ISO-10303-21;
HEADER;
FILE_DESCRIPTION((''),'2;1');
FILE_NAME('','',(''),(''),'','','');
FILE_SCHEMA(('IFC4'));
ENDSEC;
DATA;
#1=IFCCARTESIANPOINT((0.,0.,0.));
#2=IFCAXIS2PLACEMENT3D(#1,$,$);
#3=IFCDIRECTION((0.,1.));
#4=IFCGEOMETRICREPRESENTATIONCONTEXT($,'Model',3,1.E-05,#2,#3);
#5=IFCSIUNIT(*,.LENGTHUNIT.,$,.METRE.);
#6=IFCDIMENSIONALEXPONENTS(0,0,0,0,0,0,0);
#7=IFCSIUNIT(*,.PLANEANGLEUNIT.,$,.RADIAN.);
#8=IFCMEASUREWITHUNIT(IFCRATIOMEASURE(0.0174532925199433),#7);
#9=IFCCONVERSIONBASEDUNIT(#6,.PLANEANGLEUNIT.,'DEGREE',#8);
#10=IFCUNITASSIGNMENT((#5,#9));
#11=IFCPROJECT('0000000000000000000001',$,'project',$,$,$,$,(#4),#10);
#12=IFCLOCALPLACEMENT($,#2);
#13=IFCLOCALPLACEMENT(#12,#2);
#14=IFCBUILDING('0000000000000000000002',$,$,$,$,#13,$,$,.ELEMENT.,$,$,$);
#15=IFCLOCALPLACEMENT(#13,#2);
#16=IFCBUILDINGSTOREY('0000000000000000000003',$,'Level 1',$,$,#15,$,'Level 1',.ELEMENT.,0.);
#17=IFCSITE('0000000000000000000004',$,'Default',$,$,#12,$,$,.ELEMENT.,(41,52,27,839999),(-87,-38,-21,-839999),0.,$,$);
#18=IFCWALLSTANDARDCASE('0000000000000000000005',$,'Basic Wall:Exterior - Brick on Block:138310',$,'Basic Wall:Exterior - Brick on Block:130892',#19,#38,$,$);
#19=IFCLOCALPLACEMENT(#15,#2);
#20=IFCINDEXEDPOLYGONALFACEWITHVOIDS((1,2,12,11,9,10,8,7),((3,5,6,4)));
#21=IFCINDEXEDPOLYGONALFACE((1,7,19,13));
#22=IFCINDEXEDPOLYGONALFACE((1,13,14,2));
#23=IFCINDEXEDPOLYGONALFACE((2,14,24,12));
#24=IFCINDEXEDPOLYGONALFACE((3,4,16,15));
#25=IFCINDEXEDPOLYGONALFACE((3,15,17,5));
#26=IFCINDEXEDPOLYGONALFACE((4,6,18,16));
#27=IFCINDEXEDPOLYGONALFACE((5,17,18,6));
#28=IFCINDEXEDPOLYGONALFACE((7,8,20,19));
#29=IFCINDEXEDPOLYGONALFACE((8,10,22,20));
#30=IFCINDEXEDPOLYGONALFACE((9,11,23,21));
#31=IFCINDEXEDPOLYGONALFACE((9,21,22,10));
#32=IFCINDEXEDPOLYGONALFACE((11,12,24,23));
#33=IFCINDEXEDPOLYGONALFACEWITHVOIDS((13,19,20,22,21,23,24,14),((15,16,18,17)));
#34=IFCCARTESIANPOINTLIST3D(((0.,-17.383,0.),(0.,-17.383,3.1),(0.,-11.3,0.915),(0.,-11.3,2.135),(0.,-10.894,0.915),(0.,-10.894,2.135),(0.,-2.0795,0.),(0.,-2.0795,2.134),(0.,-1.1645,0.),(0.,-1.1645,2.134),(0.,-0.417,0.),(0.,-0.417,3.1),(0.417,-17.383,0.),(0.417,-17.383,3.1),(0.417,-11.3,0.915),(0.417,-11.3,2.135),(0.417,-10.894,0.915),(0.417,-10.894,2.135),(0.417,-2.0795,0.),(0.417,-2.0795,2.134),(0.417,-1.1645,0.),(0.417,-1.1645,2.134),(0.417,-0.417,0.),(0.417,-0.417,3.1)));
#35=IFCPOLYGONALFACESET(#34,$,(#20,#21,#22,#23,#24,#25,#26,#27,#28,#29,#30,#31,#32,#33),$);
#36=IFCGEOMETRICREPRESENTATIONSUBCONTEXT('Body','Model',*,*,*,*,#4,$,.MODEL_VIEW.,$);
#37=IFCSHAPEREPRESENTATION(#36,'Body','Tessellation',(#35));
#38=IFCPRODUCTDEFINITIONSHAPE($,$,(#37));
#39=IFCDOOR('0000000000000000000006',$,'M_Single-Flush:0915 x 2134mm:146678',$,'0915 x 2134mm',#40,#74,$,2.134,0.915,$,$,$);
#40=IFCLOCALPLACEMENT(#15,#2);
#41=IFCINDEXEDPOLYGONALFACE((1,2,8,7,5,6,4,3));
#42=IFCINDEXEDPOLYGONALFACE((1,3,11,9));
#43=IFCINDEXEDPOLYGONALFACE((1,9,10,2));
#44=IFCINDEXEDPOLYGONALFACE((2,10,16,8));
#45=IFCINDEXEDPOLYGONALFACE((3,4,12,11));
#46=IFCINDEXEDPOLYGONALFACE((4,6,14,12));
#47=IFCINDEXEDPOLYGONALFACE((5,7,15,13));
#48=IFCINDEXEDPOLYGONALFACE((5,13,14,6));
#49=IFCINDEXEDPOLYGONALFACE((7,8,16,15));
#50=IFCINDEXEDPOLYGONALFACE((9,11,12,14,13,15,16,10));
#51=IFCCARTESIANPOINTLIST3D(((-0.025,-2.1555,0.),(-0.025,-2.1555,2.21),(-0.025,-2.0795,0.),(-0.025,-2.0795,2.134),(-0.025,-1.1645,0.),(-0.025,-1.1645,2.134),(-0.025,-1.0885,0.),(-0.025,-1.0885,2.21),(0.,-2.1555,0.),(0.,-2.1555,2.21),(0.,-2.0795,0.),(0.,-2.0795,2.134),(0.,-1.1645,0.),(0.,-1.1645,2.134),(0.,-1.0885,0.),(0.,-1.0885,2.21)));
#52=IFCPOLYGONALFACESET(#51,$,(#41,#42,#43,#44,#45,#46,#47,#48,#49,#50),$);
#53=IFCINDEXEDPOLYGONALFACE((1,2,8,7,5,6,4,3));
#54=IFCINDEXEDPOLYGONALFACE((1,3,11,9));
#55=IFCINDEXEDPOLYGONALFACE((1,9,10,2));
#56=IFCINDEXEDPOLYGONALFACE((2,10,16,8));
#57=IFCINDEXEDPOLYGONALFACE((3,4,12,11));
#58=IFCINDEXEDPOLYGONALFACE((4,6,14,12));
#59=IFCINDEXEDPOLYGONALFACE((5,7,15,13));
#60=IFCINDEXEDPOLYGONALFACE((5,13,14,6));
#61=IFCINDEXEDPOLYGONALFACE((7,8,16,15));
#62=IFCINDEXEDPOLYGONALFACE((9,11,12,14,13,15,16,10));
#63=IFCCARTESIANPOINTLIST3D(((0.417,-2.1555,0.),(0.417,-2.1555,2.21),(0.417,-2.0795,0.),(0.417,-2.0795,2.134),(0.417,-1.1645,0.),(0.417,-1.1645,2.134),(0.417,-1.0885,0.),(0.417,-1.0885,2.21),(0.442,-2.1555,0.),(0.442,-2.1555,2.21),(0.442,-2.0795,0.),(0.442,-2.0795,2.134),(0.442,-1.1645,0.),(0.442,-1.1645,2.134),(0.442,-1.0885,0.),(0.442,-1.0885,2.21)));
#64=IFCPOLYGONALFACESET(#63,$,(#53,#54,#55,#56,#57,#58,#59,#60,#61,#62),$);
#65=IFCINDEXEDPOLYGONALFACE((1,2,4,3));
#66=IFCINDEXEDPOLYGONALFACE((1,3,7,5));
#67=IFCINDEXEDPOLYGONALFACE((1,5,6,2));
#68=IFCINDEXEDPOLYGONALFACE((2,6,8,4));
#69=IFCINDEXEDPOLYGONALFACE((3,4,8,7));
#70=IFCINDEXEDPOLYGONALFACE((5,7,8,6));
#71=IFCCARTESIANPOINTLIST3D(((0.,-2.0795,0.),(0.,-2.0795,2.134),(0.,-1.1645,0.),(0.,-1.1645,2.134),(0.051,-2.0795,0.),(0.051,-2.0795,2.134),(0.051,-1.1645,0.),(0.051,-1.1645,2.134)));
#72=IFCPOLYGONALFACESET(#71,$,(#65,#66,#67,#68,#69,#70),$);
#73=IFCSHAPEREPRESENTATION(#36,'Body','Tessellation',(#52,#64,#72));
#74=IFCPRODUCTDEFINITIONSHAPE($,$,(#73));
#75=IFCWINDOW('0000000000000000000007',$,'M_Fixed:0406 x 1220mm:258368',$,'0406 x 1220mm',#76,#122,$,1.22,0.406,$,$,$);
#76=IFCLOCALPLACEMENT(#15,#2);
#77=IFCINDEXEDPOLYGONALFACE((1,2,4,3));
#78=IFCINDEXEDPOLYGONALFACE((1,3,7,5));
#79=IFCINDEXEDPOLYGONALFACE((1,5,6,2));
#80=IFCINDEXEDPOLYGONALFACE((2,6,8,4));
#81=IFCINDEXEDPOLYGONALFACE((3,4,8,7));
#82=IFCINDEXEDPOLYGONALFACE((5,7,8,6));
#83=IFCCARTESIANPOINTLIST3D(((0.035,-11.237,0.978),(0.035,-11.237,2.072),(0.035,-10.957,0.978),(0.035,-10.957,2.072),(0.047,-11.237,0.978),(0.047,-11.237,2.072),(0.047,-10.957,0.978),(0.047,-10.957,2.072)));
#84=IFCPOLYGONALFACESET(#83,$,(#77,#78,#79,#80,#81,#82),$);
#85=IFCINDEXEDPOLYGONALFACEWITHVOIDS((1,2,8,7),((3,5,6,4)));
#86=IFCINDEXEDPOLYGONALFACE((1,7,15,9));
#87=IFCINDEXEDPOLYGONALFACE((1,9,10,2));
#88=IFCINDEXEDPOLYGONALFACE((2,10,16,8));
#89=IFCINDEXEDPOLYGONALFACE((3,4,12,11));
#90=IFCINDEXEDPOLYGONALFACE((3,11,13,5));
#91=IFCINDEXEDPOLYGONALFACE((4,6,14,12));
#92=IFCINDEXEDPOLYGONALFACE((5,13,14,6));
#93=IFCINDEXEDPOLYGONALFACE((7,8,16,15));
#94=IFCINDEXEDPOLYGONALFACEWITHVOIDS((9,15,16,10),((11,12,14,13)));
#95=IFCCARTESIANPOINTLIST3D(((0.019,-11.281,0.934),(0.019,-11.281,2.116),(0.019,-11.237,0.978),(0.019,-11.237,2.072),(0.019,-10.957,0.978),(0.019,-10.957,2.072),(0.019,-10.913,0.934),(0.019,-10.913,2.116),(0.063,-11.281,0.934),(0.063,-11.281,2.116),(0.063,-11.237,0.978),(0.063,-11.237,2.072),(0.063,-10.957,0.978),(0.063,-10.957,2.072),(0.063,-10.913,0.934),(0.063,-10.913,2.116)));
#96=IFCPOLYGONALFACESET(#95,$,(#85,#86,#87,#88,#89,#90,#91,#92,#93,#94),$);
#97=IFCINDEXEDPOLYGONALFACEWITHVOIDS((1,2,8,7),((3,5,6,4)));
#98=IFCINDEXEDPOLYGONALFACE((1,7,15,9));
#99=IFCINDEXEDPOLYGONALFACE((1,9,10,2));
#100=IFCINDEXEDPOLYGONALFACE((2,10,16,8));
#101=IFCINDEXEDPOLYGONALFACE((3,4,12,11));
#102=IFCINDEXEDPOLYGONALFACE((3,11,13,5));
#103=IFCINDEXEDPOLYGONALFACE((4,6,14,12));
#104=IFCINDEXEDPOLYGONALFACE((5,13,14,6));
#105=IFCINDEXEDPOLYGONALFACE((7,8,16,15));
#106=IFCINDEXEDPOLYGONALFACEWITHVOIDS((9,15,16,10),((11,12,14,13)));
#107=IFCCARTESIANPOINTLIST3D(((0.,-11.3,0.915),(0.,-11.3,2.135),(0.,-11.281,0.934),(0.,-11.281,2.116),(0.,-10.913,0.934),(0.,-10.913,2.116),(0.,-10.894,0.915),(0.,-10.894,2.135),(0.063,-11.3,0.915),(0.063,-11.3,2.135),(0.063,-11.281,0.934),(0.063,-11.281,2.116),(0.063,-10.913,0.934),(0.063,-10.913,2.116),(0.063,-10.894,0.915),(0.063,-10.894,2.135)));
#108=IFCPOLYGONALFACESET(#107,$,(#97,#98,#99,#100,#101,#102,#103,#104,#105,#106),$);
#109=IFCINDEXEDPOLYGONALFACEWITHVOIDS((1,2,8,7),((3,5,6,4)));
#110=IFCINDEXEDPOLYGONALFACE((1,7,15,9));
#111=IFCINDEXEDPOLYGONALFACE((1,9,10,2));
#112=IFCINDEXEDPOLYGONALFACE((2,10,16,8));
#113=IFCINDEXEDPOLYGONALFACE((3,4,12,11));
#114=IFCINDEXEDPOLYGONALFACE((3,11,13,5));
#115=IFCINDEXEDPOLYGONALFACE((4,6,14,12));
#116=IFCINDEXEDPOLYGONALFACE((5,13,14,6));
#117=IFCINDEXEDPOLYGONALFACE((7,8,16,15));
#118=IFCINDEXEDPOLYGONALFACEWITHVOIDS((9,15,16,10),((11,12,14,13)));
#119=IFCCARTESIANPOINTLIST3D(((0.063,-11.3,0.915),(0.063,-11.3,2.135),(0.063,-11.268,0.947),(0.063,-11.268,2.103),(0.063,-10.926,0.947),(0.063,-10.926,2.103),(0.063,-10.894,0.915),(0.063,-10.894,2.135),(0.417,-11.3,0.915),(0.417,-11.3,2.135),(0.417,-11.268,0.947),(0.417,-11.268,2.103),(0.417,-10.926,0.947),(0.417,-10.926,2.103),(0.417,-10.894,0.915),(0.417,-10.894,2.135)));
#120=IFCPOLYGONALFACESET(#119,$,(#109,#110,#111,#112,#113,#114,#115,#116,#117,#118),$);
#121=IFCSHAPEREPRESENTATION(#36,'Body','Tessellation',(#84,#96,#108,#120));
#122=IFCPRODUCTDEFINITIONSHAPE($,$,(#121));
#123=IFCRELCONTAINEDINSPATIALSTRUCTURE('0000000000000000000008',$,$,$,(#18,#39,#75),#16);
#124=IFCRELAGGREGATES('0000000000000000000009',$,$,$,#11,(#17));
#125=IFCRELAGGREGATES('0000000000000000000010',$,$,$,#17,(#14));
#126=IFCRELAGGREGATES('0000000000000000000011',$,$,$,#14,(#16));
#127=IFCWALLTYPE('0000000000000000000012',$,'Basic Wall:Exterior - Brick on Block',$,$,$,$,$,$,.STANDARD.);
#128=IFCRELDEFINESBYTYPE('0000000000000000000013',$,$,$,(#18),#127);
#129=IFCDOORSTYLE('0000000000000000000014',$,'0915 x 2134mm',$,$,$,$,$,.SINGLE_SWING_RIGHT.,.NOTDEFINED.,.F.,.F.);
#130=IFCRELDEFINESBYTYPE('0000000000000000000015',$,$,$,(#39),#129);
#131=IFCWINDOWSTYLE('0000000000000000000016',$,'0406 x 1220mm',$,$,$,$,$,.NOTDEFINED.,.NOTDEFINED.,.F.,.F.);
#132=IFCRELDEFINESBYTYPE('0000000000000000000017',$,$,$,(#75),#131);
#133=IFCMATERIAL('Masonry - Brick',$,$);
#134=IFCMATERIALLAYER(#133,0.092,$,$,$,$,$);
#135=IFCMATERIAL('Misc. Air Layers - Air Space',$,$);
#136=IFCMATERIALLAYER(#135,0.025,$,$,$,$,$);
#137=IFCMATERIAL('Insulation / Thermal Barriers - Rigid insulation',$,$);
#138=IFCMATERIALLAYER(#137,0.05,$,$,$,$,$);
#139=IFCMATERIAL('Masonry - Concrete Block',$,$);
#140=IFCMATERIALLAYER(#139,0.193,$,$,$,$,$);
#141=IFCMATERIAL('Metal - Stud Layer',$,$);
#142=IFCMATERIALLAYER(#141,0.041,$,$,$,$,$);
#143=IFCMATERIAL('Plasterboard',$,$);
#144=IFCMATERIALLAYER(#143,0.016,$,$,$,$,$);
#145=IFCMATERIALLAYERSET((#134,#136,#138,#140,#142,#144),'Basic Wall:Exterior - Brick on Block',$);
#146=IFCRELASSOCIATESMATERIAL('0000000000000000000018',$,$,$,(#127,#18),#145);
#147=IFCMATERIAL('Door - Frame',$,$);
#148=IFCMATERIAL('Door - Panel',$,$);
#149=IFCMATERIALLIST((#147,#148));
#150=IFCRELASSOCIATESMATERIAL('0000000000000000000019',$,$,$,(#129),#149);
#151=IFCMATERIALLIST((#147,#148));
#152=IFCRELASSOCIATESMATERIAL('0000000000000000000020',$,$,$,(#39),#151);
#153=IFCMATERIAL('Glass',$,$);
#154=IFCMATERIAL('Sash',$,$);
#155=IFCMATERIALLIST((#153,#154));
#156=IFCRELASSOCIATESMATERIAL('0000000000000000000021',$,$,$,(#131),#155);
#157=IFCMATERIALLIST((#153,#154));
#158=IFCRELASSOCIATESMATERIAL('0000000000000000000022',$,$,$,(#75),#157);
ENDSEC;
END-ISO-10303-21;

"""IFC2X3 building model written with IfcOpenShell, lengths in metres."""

from ifc_helpers import new_model, entity, si_unit, converted_unit, direction, frame, frame_2d, origin, origin_2d_with_axis, place, context, subcontext, project, spatial, polyline, rectangle, outline, extrude, source, transform, mapped, material, material_list, layer, layer_set, layer_usage, type_object, type_shapes, element, fill, save


model = new_model("IFC2X3")

# Units and contexts
model_context = context("Model", 3, precision=1e-05, world=origin(), true_north=direction((0.0, 1.0)))
body_context = subcontext(model_context, "Body", "Model", "MODEL_VIEW")
ifc_project = project(units=[si_unit("LENGTHUNIT", "METRE"), converted_unit("PLANEANGLEUNIT", "DEGREE", entity("IfcRatioMeasure", 0.0174532925199433), si_unit("PLANEANGLEUNIT", "RADIAN"), dimensions=[0, 0, 0, 0, 0, 0, 0])], contexts=[model_context])

# Site, building, storey
site_placement = place(None, origin())
site = spatial("IfcSite", under=ifc_project, at=site_placement, Name="Default", CompositionType="ELEMENT", RefLatitude=(41, 52, 27, 839999), RefLongitude=(-87, -38, -21, -839999), RefElevation=0.0)
building_placement = place(site_placement, origin())
building = spatial("IfcBuilding", under=site, at=building_placement, CompositionType="ELEMENT")
storey_placement = place(building_placement, origin())
storey = spatial("IfcBuildingStorey", under=building, at=storey_placement, Name="Level 1", LongName="Level 1", CompositionType="ELEMENT", Elevation=0.0)

# Shared definitions
ifc_material_1 = material(Name="Masonry - Brick")
ifc_layer_1 = layer(ifc_material_1, 0.092)
ifc_material_2 = material(Name="Misc. Air Layers - Air Space")
ifc_layer_2 = layer(ifc_material_2, 0.025)
ifc_material_3 = material(Name="Insulation / Thermal Barriers - Rigid insulation")
ifc_layer_3 = layer(ifc_material_3, 0.05)
ifc_material_4 = material(Name="Masonry - Concrete Block")
ifc_layer_4 = layer(ifc_material_4, 0.193)
ifc_material_5 = material(Name="Metal - Stud Layer")
ifc_layer_5 = layer(ifc_material_5, 0.041)
ifc_material_6 = material(Name="Plasterboard")
ifc_layer_6 = layer(ifc_material_6, 0.016)
ifc_layer_set_1 = layer_set([ifc_layer_1, ifc_layer_2, ifc_layer_3, ifc_layer_4, ifc_layer_5, ifc_layer_6], Name="Basic Wall:Exterior - Brick on Block")
wall_type_1 = type_object("IfcWallType", Name="Basic Wall:Exterior - Brick on Block", PredefinedType="STANDARD", material=ifc_layer_set_1)
ifc_material_7 = material(Name="Glass")
ifc_material_8 = material(Name="Sash")
ifc_material_9 = material(Name="Door - Frame")
ifc_material_10 = material(Name="Door - Panel")

# Wall, openings, door, window
ifc_layer_usage_1 = layer_usage(ifc_layer_set_1, "AXIS2", "NEGATIVE", 0.2085)
wall_1_placement = place(storey_placement, frame((0.2085, -17.383, 0.0), z_axis=(0.0, 0.0, 1.0), x_axis=(0.0, 1.0, 0.0)))
wall_1 = element("IfcWallStandardCase", 1, at=wall_1_placement, inside=storey, type_object=wall_type_1, material=ifc_layer_usage_1, Name="Basic Wall:Exterior - Brick on Block:138310", ObjectType="Basic Wall:Exterior - Brick on Block:130892", context=body_context, shape_type="SweptSolid", body=[
    extrude(rectangle(XDim=16.966, YDim=0.417, at=frame_2d((8.483, 0.0), x_axis=(-1.0, 0.0))), origin(), (0.0, 0.0, 1.0), 3.1),
])
opening_1_placement = place(wall_1_placement, frame((15.3035, -0.2085, 0.0)))
opening_1 = element("IfcOpeningElement", 2, at=opening_1_placement, cuts=wall_1, ObjectType="Opening", context=body_context, shape_type="SweptSolid", body=[
    extrude(rectangle(XDim=0.915, YDim=2.134, at=frame_2d((1.067, 0.4575), x_axis=(0.0, 1.0))), frame((0.0, 0.0, 0.0), z_axis=(0.0, 1.0, 0.0), x_axis=(0.0, 0.0, 1.0)), (0.0, 0.0, 1.0), 0.417),
])
opening_2_placement = place(wall_1_placement, frame((6.083, -0.2085, 0.915)))
opening_2 = element("IfcOpeningElement", 3, at=opening_2_placement, cuts=wall_1, ObjectType="Opening", context=body_context, shape_type="SweptSolid", body=[
    extrude(rectangle(XDim=1.22, YDim=0.406, at=frame_2d((0.61, 0.203), x_axis=(1.0, 0.0))), frame((0.0, 0.0, 0.0), z_axis=(0.0, 1.0, 0.0), x_axis=(0.0, 0.0, 1.0)), (0.0, 0.0, 1.0), 0.417),
])
ifc_material_list_1 = material_list([ifc_material_9, ifc_material_10])
ifc_material_list_2 = material_list([ifc_material_9, ifc_material_10])
door_style_1 = type_object("IfcDoorStyle", Name="0915 x 2134mm", ConstructionType="NOTDEFINED", OperationType="SINGLE_SWING_RIGHT", ParameterTakesPrecedence=False, Sizeable=False, material=ifc_material_list_2)
shared_shape_1 = source(origin(), body_context, "Body", "SweptSolid", [
    extrude(outline(polyline([(-0.5335, -1.124), (0.5335, -1.124), (0.5335, 1.086), (0.4575, 1.086), (0.4575, -1.048), (-0.4575, -1.048), (-0.4575, 1.086), (-0.5335, 1.086), (-0.5335, -1.124)])), frame((0.4575, 0.417, 1.086), z_axis=(0.0, 1.0, 0.0), x_axis=(1.0, 0.0, 0.0)), (0.0, 0.0, 1.0), 0.025),
    extrude(outline(polyline([(-1.124, -0.5335), (1.086, -0.5335), (1.086, -0.4575), (-1.048, -0.4575), (-1.048, 0.4575), (1.086, 0.4575), (1.086, 0.5335), (-1.124, 0.5335), (-1.124, -0.5335)])), frame((0.4575, -0.025, 1.086), z_axis=(0.0, 1.0, 0.0), x_axis=(0.0, 0.0, -1.0)), (0.0, 0.0, 1.0), 0.025),
    extrude(rectangle(XDim=0.051, YDim=0.915, at=frame_2d((0.0, 0.0), x_axis=(1.0, 0.0))), frame((0.4575, 0.3915, 0.0), z_axis=(0.0, 0.0, 1.0), x_axis=(0.0, 1.0, 0.0)), (0.0, 0.0, 1.0), 2.134),
])
type_shapes(door_style_1, [shared_shape_1])
door_1_placement = place(opening_1_placement, origin())
door_1 = element("IfcDoor", 4, at=door_1_placement, inside=storey, type_object=door_style_1, material=ifc_material_list_1, Name="M_Single-Flush:0915 x 2134mm:146678", ObjectType="0915 x 2134mm", OverallHeight=2.134, OverallWidth=0.915, context=body_context, shape_type="MappedRepresentation", body=[
    mapped(shared_shape_1, transform((0.0, 0.0, 0.0), scale=1.0)),
])
fill(opening_1, door_1)
ifc_material_list_3 = material_list([ifc_material_7, ifc_material_8])
ifc_material_list_4 = material_list([ifc_material_7, ifc_material_8])
window_style_1 = type_object("IfcWindowStyle", Name="0406 x 1220mm", ConstructionType="NOTDEFINED", OperationType="NOTDEFINED", ParameterTakesPrecedence=False, Sizeable=False, material=ifc_material_list_4)
shared_shape_2 = source(origin(), body_context, "Body", "SweptSolid", [
    extrude(rectangle(XDim=0.012, YDim=0.28, at=origin_2d_with_axis()), frame((0.203, 0.376, 0.063), z_axis=(0.0, 0.0, 1.0), x_axis=(0.0, -1.0, 0.0)), (0.0, 0.0, 1.0), 1.094),
    extrude(outline(polyline([(-0.184, -0.591), (0.184, -0.591), (0.184, 0.591), (-0.184, 0.591), (-0.184, -0.591)]), holes=[polyline([(-0.14, -0.547), (-0.14, 0.547), (0.14, 0.547), (0.14, -0.547), (-0.14, -0.547)])]), frame((0.203, 0.354, 0.61), z_axis=(0.0, 1.0, 0.0), x_axis=(1.0, 0.0, 0.0)), (0.0, 0.0, 1.0), 0.044),
    extrude(outline(polyline([(-0.203, -0.61), (0.203, -0.61), (0.203, 0.61), (-0.203, 0.61), (-0.203, -0.61)]), holes=[polyline([(-0.184, -0.591), (-0.184, 0.591), (0.184, 0.591), (0.184, -0.591), (-0.184, -0.591)])]), frame((0.203, 0.354, 0.61), z_axis=(0.0, 1.0, 0.0), x_axis=(1.0, 0.0, 0.0)), (0.0, 0.0, 1.0), 0.063),
    extrude(outline(polyline([(-0.203, -0.61), (0.203, -0.61), (0.203, 0.61), (-0.203, 0.61), (-0.203, -0.61)]), holes=[polyline([(-0.171, -0.578), (-0.171, 0.578), (0.171, 0.578), (0.171, -0.578), (-0.171, -0.578)])]), frame((0.203, 0.0, 0.61), z_axis=(0.0, 1.0, 0.0), x_axis=(1.0, 0.0, 0.0)), (0.0, 0.0, 1.0), 0.354),
])
type_shapes(window_style_1, [shared_shape_2])
window_1_placement = place(opening_2_placement, origin())
window_1 = element("IfcWindow", 5, at=window_1_placement, inside=storey, type_object=window_style_1, material=ifc_material_list_3, Name="M_Fixed:0406 x 1220mm:258368", ObjectType="0406 x 1220mm", OverallHeight=1.22, OverallWidth=0.406, context=body_context, shape_type="MappedRepresentation", body=[
    mapped(shared_shape_2, transform((0.0, 0.0, 0.0), scale=1.0)),
])
fill(opening_2, window_1)

save(model, "model.ifc")
